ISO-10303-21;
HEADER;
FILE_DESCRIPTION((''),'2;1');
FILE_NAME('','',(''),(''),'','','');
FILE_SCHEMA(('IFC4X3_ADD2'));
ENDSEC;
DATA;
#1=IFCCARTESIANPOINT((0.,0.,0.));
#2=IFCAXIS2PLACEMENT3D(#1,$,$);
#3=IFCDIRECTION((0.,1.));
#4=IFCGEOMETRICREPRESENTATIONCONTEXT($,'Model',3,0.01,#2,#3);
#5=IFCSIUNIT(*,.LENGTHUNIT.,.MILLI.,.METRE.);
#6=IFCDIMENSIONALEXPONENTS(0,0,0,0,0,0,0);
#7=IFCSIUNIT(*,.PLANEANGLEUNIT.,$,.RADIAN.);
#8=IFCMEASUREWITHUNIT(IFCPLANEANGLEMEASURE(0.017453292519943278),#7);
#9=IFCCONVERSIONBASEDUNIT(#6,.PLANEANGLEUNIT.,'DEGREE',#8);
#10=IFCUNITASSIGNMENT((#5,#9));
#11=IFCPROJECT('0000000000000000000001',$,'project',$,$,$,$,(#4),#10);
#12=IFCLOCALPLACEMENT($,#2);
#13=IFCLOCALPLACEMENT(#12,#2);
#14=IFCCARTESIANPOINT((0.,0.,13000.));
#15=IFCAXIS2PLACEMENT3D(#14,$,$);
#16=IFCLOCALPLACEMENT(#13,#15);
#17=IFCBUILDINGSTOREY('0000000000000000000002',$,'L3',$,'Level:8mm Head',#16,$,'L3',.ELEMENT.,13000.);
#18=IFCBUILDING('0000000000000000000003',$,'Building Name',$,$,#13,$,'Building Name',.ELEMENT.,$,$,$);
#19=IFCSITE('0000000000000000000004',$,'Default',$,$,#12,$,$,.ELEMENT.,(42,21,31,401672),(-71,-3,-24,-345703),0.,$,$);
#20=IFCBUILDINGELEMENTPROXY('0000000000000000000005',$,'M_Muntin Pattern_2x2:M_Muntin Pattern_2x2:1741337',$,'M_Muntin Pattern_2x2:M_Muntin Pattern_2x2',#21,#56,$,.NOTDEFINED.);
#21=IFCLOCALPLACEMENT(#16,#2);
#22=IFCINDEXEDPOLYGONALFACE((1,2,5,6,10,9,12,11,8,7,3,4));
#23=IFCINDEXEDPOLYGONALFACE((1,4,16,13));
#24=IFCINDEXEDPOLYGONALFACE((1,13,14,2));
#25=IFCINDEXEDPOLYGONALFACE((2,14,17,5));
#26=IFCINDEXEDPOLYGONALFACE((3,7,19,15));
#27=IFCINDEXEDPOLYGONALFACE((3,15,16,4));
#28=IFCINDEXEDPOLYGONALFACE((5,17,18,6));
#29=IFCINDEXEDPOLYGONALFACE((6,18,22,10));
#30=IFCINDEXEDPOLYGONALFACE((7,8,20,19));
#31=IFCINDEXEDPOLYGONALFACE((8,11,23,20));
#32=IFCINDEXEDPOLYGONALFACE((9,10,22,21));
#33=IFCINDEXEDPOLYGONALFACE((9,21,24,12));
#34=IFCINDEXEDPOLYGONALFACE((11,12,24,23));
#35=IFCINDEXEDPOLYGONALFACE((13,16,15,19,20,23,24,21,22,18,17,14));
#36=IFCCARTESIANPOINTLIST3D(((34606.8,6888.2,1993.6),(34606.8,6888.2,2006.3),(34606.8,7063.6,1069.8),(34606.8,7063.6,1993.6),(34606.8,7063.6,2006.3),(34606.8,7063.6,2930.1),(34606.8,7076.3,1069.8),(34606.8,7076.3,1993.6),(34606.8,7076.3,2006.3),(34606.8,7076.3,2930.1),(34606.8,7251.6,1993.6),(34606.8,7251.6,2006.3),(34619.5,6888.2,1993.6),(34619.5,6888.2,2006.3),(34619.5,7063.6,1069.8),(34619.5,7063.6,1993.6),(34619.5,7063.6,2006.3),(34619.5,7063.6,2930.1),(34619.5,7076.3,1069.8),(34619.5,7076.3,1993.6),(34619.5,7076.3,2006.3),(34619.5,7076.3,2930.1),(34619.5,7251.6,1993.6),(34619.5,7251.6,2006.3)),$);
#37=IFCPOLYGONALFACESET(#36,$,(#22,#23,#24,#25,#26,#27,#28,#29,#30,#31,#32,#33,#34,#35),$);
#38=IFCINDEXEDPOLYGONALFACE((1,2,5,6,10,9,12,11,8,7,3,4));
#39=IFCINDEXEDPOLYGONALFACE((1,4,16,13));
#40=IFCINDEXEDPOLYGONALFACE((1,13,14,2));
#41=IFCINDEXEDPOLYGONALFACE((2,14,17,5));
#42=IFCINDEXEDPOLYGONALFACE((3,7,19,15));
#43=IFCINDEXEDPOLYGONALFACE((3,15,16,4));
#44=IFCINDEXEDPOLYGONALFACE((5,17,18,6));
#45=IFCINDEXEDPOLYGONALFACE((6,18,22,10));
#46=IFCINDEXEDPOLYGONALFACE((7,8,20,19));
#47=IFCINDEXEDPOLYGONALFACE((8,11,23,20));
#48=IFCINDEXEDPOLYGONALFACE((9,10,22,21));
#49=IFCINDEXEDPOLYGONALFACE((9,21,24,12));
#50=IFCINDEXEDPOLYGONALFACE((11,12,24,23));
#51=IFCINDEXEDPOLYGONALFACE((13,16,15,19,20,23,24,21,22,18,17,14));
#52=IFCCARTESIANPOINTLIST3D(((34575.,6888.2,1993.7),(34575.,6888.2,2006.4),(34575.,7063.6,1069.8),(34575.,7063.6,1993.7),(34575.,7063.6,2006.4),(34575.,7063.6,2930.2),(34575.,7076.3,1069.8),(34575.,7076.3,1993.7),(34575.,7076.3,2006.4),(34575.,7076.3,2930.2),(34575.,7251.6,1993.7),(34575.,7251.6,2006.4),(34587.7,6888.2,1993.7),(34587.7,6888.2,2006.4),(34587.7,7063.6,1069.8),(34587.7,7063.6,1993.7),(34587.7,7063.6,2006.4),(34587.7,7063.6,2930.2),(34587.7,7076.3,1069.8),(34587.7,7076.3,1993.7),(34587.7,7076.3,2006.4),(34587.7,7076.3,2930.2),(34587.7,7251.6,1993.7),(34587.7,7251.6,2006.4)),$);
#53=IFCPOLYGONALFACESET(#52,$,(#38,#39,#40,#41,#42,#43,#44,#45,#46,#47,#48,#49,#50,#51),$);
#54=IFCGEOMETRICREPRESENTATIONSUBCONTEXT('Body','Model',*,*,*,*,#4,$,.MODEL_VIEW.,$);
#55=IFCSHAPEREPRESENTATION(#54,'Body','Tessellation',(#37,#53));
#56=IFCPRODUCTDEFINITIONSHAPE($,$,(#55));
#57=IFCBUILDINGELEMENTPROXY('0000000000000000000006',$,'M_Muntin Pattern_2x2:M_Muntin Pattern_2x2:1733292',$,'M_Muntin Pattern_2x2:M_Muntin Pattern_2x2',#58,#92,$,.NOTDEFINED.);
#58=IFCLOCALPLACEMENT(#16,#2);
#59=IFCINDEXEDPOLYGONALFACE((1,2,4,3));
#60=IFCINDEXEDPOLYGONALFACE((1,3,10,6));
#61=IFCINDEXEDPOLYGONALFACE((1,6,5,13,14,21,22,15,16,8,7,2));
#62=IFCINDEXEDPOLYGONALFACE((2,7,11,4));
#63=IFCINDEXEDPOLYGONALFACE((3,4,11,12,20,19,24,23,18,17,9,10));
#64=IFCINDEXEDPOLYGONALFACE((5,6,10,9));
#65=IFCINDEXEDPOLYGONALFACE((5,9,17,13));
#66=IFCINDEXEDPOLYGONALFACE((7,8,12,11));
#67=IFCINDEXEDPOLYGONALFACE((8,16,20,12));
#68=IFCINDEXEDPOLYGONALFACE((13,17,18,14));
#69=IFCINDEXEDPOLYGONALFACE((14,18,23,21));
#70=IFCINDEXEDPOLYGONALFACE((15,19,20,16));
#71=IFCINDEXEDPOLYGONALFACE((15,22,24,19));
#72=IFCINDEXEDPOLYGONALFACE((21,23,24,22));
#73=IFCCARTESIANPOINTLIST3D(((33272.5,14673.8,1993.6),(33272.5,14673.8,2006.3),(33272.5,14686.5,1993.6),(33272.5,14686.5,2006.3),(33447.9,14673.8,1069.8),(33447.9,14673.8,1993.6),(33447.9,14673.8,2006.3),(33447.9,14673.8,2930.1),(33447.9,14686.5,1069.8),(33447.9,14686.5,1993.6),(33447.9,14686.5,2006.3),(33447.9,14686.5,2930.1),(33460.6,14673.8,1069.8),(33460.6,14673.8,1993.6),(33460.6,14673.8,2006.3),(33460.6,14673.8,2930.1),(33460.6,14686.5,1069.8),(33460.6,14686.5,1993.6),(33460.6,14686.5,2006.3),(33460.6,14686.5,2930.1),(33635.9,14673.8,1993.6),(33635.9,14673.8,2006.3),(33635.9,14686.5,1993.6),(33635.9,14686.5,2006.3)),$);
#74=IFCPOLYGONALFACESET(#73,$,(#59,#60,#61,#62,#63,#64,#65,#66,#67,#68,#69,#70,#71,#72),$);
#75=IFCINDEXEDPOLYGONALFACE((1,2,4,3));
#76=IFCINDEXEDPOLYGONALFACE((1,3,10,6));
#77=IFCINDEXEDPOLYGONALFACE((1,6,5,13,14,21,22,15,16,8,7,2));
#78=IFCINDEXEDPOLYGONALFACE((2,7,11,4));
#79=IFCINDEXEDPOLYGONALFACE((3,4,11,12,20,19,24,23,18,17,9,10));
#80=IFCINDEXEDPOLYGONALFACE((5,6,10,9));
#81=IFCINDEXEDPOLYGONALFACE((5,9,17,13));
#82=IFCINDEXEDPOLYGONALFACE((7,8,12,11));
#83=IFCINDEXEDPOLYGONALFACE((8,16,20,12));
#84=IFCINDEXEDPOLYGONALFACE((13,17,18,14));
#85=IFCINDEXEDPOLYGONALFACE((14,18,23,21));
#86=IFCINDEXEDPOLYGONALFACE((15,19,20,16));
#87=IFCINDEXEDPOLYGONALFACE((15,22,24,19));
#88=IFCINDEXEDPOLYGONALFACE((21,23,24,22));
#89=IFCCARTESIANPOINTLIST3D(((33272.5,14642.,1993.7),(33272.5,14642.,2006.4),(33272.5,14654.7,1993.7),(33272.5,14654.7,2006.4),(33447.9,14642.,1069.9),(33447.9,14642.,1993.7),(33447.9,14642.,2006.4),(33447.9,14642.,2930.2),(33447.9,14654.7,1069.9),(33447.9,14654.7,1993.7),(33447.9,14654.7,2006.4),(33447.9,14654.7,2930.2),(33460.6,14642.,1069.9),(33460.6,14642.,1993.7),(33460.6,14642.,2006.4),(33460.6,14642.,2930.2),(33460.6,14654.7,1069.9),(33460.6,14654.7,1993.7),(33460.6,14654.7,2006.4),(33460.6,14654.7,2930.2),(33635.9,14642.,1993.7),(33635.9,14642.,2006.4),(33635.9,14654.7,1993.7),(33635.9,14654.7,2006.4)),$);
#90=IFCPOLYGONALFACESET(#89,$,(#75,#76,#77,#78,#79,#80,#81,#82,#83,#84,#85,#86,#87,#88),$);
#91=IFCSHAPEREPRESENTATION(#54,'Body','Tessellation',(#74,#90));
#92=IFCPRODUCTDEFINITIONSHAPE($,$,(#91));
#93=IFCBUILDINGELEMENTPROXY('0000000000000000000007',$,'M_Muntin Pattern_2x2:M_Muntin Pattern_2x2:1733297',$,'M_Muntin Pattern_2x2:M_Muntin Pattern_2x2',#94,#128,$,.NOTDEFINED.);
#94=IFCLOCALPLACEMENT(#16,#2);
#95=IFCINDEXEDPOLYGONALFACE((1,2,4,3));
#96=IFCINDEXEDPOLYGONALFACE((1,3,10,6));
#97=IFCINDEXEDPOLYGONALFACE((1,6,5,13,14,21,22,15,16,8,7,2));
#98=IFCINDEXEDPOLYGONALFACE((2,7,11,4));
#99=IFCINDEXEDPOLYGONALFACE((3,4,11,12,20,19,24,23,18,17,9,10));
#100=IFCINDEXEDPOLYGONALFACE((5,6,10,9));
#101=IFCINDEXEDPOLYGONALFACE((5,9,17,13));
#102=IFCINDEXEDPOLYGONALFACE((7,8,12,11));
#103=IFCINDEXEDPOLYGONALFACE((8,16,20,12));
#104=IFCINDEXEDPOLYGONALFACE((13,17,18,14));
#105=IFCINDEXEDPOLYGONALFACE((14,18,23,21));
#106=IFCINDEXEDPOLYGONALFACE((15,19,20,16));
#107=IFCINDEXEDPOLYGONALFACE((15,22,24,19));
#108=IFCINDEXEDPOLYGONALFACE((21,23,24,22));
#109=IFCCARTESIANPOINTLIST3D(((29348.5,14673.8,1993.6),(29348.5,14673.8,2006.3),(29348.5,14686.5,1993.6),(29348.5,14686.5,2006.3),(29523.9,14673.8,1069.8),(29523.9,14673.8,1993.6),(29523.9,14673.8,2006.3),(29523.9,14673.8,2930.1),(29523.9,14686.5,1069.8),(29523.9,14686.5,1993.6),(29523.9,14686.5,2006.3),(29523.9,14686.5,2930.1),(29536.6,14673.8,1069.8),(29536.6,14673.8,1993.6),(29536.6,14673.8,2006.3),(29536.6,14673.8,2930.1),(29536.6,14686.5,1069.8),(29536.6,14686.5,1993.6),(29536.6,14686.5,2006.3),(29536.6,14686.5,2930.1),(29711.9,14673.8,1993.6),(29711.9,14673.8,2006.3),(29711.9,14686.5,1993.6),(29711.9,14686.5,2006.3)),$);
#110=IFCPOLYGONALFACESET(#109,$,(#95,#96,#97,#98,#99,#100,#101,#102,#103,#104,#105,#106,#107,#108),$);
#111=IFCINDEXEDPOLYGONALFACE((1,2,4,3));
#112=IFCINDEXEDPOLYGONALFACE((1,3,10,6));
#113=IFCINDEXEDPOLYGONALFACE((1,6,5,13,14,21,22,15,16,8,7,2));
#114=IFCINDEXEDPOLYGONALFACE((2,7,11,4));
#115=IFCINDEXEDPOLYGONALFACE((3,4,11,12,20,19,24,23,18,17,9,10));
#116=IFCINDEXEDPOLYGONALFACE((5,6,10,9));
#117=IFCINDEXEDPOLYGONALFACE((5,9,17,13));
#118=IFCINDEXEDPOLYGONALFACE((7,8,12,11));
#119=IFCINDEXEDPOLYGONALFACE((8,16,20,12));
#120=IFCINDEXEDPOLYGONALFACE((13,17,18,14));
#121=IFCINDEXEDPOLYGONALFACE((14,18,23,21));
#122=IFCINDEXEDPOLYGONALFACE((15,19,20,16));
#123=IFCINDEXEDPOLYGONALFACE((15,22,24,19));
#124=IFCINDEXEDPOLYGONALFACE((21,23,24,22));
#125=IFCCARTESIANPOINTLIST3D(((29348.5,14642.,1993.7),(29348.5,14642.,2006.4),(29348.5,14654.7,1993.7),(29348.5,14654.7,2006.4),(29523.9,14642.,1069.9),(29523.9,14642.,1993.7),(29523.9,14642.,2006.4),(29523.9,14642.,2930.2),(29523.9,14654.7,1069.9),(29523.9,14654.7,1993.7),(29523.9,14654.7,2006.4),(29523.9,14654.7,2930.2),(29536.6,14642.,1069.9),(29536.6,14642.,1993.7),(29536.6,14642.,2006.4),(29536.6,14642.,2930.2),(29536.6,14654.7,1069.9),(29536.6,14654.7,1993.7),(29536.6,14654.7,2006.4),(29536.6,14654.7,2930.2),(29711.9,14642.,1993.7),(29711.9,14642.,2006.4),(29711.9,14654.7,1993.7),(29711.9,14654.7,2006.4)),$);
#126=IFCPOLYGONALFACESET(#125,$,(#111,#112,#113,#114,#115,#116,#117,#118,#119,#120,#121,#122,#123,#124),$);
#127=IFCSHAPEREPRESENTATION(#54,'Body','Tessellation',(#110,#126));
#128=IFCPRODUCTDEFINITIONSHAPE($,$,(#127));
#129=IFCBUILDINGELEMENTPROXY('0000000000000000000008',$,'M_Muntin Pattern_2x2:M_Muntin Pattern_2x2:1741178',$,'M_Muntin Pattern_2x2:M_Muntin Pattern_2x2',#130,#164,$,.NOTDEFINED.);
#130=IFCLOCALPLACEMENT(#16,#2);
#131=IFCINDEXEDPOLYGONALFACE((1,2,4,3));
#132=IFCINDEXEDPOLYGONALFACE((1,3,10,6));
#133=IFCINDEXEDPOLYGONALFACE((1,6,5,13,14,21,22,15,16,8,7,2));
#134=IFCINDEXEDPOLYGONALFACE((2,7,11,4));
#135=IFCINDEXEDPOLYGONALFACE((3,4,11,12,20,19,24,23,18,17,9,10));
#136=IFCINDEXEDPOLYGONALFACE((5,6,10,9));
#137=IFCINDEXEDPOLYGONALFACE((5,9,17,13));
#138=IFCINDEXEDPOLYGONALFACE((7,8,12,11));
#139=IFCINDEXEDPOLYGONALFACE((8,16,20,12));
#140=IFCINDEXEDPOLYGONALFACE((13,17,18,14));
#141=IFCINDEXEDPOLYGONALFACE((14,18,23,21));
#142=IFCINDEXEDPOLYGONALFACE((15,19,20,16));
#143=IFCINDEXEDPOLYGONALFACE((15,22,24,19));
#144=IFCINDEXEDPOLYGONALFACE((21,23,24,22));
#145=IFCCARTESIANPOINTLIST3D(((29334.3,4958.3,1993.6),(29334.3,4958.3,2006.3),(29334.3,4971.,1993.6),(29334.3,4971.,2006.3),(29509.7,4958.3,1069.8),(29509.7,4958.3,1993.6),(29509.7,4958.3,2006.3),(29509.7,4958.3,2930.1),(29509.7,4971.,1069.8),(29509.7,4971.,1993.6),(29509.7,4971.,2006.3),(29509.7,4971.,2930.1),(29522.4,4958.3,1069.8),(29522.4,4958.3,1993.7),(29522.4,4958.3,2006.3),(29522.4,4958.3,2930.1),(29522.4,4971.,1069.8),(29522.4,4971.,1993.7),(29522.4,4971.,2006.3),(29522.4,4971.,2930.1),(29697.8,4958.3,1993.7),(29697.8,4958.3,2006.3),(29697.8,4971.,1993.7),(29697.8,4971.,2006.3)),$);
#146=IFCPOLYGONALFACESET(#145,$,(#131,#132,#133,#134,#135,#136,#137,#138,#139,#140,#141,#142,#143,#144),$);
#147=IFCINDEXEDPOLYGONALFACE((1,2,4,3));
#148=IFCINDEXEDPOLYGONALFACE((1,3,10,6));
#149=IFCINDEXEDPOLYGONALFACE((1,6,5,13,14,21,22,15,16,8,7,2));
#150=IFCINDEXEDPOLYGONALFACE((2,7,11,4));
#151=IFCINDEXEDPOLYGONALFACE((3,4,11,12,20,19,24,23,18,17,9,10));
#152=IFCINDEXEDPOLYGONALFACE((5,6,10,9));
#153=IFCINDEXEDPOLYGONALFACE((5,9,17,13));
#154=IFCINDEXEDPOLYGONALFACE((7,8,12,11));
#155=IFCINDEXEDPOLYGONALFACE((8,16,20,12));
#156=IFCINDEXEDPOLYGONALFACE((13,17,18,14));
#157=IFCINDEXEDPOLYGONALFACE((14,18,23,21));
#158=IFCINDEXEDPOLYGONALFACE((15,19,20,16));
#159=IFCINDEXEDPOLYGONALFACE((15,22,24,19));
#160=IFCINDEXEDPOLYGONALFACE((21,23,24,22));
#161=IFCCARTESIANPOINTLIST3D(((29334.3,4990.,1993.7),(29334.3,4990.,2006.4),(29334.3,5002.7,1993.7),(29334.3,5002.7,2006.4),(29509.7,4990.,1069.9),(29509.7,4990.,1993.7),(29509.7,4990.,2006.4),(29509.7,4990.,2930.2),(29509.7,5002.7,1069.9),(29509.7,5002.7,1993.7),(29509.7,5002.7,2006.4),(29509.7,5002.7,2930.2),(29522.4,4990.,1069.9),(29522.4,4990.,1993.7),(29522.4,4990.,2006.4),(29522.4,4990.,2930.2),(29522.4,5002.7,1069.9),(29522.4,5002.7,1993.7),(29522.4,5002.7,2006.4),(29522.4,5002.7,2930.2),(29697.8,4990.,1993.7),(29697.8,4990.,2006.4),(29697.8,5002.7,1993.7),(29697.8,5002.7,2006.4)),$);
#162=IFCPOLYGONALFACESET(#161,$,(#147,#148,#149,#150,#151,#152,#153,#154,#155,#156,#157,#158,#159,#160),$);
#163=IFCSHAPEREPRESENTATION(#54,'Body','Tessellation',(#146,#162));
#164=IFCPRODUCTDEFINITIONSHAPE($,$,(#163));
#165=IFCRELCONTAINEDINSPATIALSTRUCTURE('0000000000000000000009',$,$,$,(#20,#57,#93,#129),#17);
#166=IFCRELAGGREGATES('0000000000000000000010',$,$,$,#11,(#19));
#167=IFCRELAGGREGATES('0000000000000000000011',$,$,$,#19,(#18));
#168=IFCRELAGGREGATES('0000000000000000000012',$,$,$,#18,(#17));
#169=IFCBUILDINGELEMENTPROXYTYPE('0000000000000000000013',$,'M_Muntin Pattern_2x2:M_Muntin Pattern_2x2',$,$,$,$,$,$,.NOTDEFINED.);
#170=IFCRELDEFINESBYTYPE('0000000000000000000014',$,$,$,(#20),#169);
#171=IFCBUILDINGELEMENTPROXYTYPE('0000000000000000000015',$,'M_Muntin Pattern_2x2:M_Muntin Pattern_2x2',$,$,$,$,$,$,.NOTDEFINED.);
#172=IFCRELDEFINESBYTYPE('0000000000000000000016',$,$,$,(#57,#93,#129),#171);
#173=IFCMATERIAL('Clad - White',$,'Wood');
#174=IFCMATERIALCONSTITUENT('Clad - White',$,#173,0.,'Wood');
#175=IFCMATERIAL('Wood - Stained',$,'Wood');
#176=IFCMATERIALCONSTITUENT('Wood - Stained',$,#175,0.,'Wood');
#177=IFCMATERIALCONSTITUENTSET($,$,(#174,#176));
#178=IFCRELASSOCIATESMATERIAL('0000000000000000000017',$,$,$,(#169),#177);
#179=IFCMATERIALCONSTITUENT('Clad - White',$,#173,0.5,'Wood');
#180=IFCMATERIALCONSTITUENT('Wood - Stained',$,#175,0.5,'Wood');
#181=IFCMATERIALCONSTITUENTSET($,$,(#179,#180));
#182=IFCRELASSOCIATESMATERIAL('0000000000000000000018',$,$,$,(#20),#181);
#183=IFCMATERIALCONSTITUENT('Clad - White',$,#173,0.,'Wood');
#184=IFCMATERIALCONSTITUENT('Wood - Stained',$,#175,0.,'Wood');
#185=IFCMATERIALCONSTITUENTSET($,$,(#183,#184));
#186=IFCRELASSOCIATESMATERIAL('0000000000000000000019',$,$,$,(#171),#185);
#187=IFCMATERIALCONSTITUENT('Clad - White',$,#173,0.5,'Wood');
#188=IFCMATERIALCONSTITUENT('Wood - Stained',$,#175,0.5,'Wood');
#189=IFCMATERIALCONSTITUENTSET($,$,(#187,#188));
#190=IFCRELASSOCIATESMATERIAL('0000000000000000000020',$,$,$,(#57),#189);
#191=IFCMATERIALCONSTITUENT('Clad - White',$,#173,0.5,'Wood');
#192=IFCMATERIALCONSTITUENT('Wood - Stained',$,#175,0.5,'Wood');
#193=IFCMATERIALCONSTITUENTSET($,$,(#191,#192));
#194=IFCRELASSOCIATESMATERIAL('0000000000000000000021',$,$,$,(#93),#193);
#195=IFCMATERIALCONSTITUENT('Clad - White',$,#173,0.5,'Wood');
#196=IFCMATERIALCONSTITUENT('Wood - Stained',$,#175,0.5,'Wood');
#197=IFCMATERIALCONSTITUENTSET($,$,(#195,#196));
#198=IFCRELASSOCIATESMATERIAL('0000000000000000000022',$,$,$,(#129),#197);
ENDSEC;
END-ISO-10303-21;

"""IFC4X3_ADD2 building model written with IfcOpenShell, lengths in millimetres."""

from ifc_helpers import new_model, entity, si_unit, converted_unit, direction, frame, origin, place, context, subcontext, project, spatial, polyline, outline, extrude, source, transform, mapped, material, constituent, constituent_set, type_object, type_shapes, element, save


model = new_model("IFC4X3_ADD2")

# Units and contexts
model_context = context("Model", 3, precision=0.01, world=origin(), true_north=direction((0.0, 1.0)))
body_context = subcontext(model_context, "Body", "Model", "MODEL_VIEW")
ifc_project = project(units=[si_unit("LENGTHUNIT", "METRE", prefix="MILLI"), converted_unit("PLANEANGLEUNIT", "DEGREE", entity("IfcPlaneAngleMeasure", 0.017453292519943278), si_unit("PLANEANGLEUNIT", "RADIAN"), dimensions=[0, 0, 0, 0, 0, 0, 0])], contexts=[model_context])

# Site, building, storey
site_placement = place(None, origin())
site = spatial("IfcSite", under=ifc_project, at=site_placement, Name="Default", CompositionType="ELEMENT", RefLatitude=(42, 21, 31, 401672), RefLongitude=(-71, -3, -24, -345703), RefElevation=0.0)
building_placement = place(site_placement, origin())
building = spatial("IfcBuilding", under=site, at=building_placement, Name="Building Name", LongName="Building Name", CompositionType="ELEMENT")
storey_placement = place(building_placement, frame((0.0, 0.0, 13000.0)))
storey = spatial("IfcBuildingStorey", under=building, at=storey_placement, Name="L3", ObjectType="Level:8mm Head", LongName="L3", CompositionType="ELEMENT", Elevation=13000.0)

# Building element proxies
ifc_material_1 = material(Name="Clad - White", Category="Wood")
ifc_material_2 = material(Name="Wood - Stained", Category="Wood")
ifc_constituent_1 = constituent(ifc_material_1, Name="Clad - White", Category="Wood", fraction=0.0)
ifc_constituent_2 = constituent(ifc_material_2, Name="Wood - Stained", Category="Wood", fraction=0.0)
ifc_constituent_set_1 = constituent_set(constituents=[ifc_constituent_1, ifc_constituent_2])
building_element_proxy_type_1 = type_object("IfcBuildingElementProxyType", Name="M_Muntin Pattern_2x2:M_Muntin Pattern_2x2", PredefinedType="NOTDEFINED", material=ifc_constituent_set_1)
shared_shape_1 = source(origin(), body_context, "Body", "SweptSolid", [
    extrude(outline(polyline([(6.4, -6.4), (930.1, -6.4), (930.1, 6.3), (6.4, 6.3), (6.4, 181.7), (-6.3, 181.7), (-6.3, 6.3), (-930.2, 6.3), (-930.2, -6.4), (-6.3, -6.4), (-6.3, -181.7), (6.4, -181.7), (6.4, -6.4)])), frame((0.0, 9.5, 930.1), z_axis=(0.0, 1.0, 0.0), x_axis=(0.0, 0.0, 1.0)), (0.0, 0.0, 1.0), 12.7),
    extrude(outline(polyline([(6.4, -6.4), (930.2, -6.4), (930.2, 6.3), (6.4, 6.3), (6.4, 181.7), (-6.3, 181.7), (-6.3, 6.3), (-930.2, 6.3), (-930.2, -6.4), (-6.3, -6.4), (-6.3, -181.7), (6.4, -181.7), (6.4, -6.4)])), frame((0.0, -22.2, 930.2), z_axis=(0.0, 1.0, 0.0), x_axis=(0.0, 0.0, 1.0)), (0.0, 0.0, 1.0), 12.7),
])
type_shapes(building_element_proxy_type_1, [shared_shape_1])
ifc_constituent_3 = constituent(ifc_material_1, Name="Clad - White", Category="Wood", fraction=0.5)
ifc_constituent_4 = constituent(ifc_material_2, Name="Wood - Stained", Category="Wood", fraction=0.5)
ifc_constituent_set_2 = constituent_set(constituents=[ifc_constituent_3, ifc_constituent_4])
proxy_1_placement = place(storey_placement, frame((34597.3, 7069.9, 1069.8), z_axis=(0.0, 0.0, 1.0), x_axis=(0.0, -1.0, 0.0)))
element("IfcBuildingElementProxy", 1, at=proxy_1_placement, inside=storey, type_object=building_element_proxy_type_1, material=ifc_constituent_set_2, Name="M_Muntin Pattern_2x2:M_Muntin Pattern_2x2:1741337", ObjectType="M_Muntin Pattern_2x2:M_Muntin Pattern_2x2", PredefinedType="NOTDEFINED", context=body_context, shape_type="MappedRepresentation", body=[
    mapped(shared_shape_1, transform((0.0, 0.0, 0.0), scale=1.0)),
])
ifc_constituent_5 = constituent(ifc_material_1, Name="Clad - White", Category="Wood", fraction=0.5)
ifc_constituent_6 = constituent(ifc_material_2, Name="Wood - Stained", Category="Wood", fraction=0.5)
ifc_constituent_set_3 = constituent_set(constituents=[ifc_constituent_5, ifc_constituent_6])
ifc_constituent_7 = constituent(ifc_material_1, Name="Clad - White", Category="Wood", fraction=0.0)
ifc_constituent_8 = constituent(ifc_material_2, Name="Wood - Stained", Category="Wood", fraction=0.0)
ifc_constituent_set_4 = constituent_set(constituents=[ifc_constituent_7, ifc_constituent_8])
building_element_proxy_type_2 = type_object("IfcBuildingElementProxyType", Name="M_Muntin Pattern_2x2:M_Muntin Pattern_2x2", PredefinedType="NOTDEFINED", material=ifc_constituent_set_4)
shared_shape_2 = source(origin(), body_context, "Body", "SweptSolid", [
    extrude(outline(polyline([(6.4, -6.4), (930.1, -6.4), (930.1, 6.3), (6.4, 6.3), (6.4, 181.7), (-6.3, 181.7), (-6.3, 6.3), (-930.2, 6.3), (-930.2, -6.4), (-6.3, -6.4), (-6.3, -181.7), (6.4, -181.7), (6.4, -6.4)])), frame((0.0, -22.2, 930.1), z_axis=(0.0, 1.0, 0.0), x_axis=(0.0, 0.0, 1.0)), (0.0, 0.0, 1.0), 12.7),
    extrude(outline(polyline([(6.4, -6.4), (930.2, -6.4), (930.2, 6.3), (6.4, 6.3), (6.4, 181.7), (-6.3, 181.7), (-6.3, 6.3), (-930.2, 6.3), (-930.2, -6.4), (-6.3, -6.4), (-6.3, -181.7), (6.4, -181.7), (6.4, -6.4)])), frame((0.0, 9.5, 930.2), z_axis=(0.0, 1.0, 0.0), x_axis=(0.0, 0.0, 1.0)), (0.0, 0.0, 1.0), 12.7),
])
type_shapes(building_element_proxy_type_2, [shared_shape_2])
proxy_2_placement = place(storey_placement, frame((33454.2, 14664.3, 1069.9), z_axis=(0.0, 0.0, 1.0), x_axis=(-1.0, 0.0, 0.0)))
element("IfcBuildingElementProxy", 2, at=proxy_2_placement, inside=storey, type_object=building_element_proxy_type_2, material=ifc_constituent_set_3, Name="M_Muntin Pattern_2x2:M_Muntin Pattern_2x2:1733292", ObjectType="M_Muntin Pattern_2x2:M_Muntin Pattern_2x2", PredefinedType="NOTDEFINED", context=body_context, shape_type="MappedRepresentation", body=[
    mapped(shared_shape_2, transform((0.0, 0.0, 0.0), scale=1.0)),
])
ifc_constituent_9 = constituent(ifc_material_1, Name="Clad - White", Category="Wood", fraction=0.5)
ifc_constituent_10 = constituent(ifc_material_2, Name="Wood - Stained", Category="Wood", fraction=0.5)
ifc_constituent_set_5 = constituent_set(constituents=[ifc_constituent_9, ifc_constituent_10])
proxy_3_placement = place(storey_placement, frame((29530.2, 14664.3, 1069.9), z_axis=(0.0, 0.0, 1.0), x_axis=(-1.0, 0.0, 0.0)))
element("IfcBuildingElementProxy", 3, at=proxy_3_placement, inside=storey, type_object=building_element_proxy_type_2, material=ifc_constituent_set_5, Name="M_Muntin Pattern_2x2:M_Muntin Pattern_2x2:1733297", ObjectType="M_Muntin Pattern_2x2:M_Muntin Pattern_2x2", PredefinedType="NOTDEFINED", context=body_context, shape_type="MappedRepresentation", body=[
    mapped(shared_shape_2, transform((0.0, 0.0, 0.0), scale=1.0)),
])
ifc_constituent_11 = constituent(ifc_material_1, Name="Clad - White", Category="Wood", fraction=0.5)
ifc_constituent_12 = constituent(ifc_material_2, Name="Wood - Stained", Category="Wood", fraction=0.5)
ifc_constituent_set_6 = constituent_set(constituents=[ifc_constituent_11, ifc_constituent_12])
proxy_4_placement = place(storey_placement, frame((29516.0, 4980.5, 1069.9)))
element("IfcBuildingElementProxy", 4, at=proxy_4_placement, inside=storey, type_object=building_element_proxy_type_2, material=ifc_constituent_set_6, Name="M_Muntin Pattern_2x2:M_Muntin Pattern_2x2:1741178", ObjectType="M_Muntin Pattern_2x2:M_Muntin Pattern_2x2", PredefinedType="NOTDEFINED", context=body_context, shape_type="MappedRepresentation", body=[
    mapped(shared_shape_2, transform((0.0, 0.0, 0.0), scale=1.0)),
])

save(model, "model.ifc")
